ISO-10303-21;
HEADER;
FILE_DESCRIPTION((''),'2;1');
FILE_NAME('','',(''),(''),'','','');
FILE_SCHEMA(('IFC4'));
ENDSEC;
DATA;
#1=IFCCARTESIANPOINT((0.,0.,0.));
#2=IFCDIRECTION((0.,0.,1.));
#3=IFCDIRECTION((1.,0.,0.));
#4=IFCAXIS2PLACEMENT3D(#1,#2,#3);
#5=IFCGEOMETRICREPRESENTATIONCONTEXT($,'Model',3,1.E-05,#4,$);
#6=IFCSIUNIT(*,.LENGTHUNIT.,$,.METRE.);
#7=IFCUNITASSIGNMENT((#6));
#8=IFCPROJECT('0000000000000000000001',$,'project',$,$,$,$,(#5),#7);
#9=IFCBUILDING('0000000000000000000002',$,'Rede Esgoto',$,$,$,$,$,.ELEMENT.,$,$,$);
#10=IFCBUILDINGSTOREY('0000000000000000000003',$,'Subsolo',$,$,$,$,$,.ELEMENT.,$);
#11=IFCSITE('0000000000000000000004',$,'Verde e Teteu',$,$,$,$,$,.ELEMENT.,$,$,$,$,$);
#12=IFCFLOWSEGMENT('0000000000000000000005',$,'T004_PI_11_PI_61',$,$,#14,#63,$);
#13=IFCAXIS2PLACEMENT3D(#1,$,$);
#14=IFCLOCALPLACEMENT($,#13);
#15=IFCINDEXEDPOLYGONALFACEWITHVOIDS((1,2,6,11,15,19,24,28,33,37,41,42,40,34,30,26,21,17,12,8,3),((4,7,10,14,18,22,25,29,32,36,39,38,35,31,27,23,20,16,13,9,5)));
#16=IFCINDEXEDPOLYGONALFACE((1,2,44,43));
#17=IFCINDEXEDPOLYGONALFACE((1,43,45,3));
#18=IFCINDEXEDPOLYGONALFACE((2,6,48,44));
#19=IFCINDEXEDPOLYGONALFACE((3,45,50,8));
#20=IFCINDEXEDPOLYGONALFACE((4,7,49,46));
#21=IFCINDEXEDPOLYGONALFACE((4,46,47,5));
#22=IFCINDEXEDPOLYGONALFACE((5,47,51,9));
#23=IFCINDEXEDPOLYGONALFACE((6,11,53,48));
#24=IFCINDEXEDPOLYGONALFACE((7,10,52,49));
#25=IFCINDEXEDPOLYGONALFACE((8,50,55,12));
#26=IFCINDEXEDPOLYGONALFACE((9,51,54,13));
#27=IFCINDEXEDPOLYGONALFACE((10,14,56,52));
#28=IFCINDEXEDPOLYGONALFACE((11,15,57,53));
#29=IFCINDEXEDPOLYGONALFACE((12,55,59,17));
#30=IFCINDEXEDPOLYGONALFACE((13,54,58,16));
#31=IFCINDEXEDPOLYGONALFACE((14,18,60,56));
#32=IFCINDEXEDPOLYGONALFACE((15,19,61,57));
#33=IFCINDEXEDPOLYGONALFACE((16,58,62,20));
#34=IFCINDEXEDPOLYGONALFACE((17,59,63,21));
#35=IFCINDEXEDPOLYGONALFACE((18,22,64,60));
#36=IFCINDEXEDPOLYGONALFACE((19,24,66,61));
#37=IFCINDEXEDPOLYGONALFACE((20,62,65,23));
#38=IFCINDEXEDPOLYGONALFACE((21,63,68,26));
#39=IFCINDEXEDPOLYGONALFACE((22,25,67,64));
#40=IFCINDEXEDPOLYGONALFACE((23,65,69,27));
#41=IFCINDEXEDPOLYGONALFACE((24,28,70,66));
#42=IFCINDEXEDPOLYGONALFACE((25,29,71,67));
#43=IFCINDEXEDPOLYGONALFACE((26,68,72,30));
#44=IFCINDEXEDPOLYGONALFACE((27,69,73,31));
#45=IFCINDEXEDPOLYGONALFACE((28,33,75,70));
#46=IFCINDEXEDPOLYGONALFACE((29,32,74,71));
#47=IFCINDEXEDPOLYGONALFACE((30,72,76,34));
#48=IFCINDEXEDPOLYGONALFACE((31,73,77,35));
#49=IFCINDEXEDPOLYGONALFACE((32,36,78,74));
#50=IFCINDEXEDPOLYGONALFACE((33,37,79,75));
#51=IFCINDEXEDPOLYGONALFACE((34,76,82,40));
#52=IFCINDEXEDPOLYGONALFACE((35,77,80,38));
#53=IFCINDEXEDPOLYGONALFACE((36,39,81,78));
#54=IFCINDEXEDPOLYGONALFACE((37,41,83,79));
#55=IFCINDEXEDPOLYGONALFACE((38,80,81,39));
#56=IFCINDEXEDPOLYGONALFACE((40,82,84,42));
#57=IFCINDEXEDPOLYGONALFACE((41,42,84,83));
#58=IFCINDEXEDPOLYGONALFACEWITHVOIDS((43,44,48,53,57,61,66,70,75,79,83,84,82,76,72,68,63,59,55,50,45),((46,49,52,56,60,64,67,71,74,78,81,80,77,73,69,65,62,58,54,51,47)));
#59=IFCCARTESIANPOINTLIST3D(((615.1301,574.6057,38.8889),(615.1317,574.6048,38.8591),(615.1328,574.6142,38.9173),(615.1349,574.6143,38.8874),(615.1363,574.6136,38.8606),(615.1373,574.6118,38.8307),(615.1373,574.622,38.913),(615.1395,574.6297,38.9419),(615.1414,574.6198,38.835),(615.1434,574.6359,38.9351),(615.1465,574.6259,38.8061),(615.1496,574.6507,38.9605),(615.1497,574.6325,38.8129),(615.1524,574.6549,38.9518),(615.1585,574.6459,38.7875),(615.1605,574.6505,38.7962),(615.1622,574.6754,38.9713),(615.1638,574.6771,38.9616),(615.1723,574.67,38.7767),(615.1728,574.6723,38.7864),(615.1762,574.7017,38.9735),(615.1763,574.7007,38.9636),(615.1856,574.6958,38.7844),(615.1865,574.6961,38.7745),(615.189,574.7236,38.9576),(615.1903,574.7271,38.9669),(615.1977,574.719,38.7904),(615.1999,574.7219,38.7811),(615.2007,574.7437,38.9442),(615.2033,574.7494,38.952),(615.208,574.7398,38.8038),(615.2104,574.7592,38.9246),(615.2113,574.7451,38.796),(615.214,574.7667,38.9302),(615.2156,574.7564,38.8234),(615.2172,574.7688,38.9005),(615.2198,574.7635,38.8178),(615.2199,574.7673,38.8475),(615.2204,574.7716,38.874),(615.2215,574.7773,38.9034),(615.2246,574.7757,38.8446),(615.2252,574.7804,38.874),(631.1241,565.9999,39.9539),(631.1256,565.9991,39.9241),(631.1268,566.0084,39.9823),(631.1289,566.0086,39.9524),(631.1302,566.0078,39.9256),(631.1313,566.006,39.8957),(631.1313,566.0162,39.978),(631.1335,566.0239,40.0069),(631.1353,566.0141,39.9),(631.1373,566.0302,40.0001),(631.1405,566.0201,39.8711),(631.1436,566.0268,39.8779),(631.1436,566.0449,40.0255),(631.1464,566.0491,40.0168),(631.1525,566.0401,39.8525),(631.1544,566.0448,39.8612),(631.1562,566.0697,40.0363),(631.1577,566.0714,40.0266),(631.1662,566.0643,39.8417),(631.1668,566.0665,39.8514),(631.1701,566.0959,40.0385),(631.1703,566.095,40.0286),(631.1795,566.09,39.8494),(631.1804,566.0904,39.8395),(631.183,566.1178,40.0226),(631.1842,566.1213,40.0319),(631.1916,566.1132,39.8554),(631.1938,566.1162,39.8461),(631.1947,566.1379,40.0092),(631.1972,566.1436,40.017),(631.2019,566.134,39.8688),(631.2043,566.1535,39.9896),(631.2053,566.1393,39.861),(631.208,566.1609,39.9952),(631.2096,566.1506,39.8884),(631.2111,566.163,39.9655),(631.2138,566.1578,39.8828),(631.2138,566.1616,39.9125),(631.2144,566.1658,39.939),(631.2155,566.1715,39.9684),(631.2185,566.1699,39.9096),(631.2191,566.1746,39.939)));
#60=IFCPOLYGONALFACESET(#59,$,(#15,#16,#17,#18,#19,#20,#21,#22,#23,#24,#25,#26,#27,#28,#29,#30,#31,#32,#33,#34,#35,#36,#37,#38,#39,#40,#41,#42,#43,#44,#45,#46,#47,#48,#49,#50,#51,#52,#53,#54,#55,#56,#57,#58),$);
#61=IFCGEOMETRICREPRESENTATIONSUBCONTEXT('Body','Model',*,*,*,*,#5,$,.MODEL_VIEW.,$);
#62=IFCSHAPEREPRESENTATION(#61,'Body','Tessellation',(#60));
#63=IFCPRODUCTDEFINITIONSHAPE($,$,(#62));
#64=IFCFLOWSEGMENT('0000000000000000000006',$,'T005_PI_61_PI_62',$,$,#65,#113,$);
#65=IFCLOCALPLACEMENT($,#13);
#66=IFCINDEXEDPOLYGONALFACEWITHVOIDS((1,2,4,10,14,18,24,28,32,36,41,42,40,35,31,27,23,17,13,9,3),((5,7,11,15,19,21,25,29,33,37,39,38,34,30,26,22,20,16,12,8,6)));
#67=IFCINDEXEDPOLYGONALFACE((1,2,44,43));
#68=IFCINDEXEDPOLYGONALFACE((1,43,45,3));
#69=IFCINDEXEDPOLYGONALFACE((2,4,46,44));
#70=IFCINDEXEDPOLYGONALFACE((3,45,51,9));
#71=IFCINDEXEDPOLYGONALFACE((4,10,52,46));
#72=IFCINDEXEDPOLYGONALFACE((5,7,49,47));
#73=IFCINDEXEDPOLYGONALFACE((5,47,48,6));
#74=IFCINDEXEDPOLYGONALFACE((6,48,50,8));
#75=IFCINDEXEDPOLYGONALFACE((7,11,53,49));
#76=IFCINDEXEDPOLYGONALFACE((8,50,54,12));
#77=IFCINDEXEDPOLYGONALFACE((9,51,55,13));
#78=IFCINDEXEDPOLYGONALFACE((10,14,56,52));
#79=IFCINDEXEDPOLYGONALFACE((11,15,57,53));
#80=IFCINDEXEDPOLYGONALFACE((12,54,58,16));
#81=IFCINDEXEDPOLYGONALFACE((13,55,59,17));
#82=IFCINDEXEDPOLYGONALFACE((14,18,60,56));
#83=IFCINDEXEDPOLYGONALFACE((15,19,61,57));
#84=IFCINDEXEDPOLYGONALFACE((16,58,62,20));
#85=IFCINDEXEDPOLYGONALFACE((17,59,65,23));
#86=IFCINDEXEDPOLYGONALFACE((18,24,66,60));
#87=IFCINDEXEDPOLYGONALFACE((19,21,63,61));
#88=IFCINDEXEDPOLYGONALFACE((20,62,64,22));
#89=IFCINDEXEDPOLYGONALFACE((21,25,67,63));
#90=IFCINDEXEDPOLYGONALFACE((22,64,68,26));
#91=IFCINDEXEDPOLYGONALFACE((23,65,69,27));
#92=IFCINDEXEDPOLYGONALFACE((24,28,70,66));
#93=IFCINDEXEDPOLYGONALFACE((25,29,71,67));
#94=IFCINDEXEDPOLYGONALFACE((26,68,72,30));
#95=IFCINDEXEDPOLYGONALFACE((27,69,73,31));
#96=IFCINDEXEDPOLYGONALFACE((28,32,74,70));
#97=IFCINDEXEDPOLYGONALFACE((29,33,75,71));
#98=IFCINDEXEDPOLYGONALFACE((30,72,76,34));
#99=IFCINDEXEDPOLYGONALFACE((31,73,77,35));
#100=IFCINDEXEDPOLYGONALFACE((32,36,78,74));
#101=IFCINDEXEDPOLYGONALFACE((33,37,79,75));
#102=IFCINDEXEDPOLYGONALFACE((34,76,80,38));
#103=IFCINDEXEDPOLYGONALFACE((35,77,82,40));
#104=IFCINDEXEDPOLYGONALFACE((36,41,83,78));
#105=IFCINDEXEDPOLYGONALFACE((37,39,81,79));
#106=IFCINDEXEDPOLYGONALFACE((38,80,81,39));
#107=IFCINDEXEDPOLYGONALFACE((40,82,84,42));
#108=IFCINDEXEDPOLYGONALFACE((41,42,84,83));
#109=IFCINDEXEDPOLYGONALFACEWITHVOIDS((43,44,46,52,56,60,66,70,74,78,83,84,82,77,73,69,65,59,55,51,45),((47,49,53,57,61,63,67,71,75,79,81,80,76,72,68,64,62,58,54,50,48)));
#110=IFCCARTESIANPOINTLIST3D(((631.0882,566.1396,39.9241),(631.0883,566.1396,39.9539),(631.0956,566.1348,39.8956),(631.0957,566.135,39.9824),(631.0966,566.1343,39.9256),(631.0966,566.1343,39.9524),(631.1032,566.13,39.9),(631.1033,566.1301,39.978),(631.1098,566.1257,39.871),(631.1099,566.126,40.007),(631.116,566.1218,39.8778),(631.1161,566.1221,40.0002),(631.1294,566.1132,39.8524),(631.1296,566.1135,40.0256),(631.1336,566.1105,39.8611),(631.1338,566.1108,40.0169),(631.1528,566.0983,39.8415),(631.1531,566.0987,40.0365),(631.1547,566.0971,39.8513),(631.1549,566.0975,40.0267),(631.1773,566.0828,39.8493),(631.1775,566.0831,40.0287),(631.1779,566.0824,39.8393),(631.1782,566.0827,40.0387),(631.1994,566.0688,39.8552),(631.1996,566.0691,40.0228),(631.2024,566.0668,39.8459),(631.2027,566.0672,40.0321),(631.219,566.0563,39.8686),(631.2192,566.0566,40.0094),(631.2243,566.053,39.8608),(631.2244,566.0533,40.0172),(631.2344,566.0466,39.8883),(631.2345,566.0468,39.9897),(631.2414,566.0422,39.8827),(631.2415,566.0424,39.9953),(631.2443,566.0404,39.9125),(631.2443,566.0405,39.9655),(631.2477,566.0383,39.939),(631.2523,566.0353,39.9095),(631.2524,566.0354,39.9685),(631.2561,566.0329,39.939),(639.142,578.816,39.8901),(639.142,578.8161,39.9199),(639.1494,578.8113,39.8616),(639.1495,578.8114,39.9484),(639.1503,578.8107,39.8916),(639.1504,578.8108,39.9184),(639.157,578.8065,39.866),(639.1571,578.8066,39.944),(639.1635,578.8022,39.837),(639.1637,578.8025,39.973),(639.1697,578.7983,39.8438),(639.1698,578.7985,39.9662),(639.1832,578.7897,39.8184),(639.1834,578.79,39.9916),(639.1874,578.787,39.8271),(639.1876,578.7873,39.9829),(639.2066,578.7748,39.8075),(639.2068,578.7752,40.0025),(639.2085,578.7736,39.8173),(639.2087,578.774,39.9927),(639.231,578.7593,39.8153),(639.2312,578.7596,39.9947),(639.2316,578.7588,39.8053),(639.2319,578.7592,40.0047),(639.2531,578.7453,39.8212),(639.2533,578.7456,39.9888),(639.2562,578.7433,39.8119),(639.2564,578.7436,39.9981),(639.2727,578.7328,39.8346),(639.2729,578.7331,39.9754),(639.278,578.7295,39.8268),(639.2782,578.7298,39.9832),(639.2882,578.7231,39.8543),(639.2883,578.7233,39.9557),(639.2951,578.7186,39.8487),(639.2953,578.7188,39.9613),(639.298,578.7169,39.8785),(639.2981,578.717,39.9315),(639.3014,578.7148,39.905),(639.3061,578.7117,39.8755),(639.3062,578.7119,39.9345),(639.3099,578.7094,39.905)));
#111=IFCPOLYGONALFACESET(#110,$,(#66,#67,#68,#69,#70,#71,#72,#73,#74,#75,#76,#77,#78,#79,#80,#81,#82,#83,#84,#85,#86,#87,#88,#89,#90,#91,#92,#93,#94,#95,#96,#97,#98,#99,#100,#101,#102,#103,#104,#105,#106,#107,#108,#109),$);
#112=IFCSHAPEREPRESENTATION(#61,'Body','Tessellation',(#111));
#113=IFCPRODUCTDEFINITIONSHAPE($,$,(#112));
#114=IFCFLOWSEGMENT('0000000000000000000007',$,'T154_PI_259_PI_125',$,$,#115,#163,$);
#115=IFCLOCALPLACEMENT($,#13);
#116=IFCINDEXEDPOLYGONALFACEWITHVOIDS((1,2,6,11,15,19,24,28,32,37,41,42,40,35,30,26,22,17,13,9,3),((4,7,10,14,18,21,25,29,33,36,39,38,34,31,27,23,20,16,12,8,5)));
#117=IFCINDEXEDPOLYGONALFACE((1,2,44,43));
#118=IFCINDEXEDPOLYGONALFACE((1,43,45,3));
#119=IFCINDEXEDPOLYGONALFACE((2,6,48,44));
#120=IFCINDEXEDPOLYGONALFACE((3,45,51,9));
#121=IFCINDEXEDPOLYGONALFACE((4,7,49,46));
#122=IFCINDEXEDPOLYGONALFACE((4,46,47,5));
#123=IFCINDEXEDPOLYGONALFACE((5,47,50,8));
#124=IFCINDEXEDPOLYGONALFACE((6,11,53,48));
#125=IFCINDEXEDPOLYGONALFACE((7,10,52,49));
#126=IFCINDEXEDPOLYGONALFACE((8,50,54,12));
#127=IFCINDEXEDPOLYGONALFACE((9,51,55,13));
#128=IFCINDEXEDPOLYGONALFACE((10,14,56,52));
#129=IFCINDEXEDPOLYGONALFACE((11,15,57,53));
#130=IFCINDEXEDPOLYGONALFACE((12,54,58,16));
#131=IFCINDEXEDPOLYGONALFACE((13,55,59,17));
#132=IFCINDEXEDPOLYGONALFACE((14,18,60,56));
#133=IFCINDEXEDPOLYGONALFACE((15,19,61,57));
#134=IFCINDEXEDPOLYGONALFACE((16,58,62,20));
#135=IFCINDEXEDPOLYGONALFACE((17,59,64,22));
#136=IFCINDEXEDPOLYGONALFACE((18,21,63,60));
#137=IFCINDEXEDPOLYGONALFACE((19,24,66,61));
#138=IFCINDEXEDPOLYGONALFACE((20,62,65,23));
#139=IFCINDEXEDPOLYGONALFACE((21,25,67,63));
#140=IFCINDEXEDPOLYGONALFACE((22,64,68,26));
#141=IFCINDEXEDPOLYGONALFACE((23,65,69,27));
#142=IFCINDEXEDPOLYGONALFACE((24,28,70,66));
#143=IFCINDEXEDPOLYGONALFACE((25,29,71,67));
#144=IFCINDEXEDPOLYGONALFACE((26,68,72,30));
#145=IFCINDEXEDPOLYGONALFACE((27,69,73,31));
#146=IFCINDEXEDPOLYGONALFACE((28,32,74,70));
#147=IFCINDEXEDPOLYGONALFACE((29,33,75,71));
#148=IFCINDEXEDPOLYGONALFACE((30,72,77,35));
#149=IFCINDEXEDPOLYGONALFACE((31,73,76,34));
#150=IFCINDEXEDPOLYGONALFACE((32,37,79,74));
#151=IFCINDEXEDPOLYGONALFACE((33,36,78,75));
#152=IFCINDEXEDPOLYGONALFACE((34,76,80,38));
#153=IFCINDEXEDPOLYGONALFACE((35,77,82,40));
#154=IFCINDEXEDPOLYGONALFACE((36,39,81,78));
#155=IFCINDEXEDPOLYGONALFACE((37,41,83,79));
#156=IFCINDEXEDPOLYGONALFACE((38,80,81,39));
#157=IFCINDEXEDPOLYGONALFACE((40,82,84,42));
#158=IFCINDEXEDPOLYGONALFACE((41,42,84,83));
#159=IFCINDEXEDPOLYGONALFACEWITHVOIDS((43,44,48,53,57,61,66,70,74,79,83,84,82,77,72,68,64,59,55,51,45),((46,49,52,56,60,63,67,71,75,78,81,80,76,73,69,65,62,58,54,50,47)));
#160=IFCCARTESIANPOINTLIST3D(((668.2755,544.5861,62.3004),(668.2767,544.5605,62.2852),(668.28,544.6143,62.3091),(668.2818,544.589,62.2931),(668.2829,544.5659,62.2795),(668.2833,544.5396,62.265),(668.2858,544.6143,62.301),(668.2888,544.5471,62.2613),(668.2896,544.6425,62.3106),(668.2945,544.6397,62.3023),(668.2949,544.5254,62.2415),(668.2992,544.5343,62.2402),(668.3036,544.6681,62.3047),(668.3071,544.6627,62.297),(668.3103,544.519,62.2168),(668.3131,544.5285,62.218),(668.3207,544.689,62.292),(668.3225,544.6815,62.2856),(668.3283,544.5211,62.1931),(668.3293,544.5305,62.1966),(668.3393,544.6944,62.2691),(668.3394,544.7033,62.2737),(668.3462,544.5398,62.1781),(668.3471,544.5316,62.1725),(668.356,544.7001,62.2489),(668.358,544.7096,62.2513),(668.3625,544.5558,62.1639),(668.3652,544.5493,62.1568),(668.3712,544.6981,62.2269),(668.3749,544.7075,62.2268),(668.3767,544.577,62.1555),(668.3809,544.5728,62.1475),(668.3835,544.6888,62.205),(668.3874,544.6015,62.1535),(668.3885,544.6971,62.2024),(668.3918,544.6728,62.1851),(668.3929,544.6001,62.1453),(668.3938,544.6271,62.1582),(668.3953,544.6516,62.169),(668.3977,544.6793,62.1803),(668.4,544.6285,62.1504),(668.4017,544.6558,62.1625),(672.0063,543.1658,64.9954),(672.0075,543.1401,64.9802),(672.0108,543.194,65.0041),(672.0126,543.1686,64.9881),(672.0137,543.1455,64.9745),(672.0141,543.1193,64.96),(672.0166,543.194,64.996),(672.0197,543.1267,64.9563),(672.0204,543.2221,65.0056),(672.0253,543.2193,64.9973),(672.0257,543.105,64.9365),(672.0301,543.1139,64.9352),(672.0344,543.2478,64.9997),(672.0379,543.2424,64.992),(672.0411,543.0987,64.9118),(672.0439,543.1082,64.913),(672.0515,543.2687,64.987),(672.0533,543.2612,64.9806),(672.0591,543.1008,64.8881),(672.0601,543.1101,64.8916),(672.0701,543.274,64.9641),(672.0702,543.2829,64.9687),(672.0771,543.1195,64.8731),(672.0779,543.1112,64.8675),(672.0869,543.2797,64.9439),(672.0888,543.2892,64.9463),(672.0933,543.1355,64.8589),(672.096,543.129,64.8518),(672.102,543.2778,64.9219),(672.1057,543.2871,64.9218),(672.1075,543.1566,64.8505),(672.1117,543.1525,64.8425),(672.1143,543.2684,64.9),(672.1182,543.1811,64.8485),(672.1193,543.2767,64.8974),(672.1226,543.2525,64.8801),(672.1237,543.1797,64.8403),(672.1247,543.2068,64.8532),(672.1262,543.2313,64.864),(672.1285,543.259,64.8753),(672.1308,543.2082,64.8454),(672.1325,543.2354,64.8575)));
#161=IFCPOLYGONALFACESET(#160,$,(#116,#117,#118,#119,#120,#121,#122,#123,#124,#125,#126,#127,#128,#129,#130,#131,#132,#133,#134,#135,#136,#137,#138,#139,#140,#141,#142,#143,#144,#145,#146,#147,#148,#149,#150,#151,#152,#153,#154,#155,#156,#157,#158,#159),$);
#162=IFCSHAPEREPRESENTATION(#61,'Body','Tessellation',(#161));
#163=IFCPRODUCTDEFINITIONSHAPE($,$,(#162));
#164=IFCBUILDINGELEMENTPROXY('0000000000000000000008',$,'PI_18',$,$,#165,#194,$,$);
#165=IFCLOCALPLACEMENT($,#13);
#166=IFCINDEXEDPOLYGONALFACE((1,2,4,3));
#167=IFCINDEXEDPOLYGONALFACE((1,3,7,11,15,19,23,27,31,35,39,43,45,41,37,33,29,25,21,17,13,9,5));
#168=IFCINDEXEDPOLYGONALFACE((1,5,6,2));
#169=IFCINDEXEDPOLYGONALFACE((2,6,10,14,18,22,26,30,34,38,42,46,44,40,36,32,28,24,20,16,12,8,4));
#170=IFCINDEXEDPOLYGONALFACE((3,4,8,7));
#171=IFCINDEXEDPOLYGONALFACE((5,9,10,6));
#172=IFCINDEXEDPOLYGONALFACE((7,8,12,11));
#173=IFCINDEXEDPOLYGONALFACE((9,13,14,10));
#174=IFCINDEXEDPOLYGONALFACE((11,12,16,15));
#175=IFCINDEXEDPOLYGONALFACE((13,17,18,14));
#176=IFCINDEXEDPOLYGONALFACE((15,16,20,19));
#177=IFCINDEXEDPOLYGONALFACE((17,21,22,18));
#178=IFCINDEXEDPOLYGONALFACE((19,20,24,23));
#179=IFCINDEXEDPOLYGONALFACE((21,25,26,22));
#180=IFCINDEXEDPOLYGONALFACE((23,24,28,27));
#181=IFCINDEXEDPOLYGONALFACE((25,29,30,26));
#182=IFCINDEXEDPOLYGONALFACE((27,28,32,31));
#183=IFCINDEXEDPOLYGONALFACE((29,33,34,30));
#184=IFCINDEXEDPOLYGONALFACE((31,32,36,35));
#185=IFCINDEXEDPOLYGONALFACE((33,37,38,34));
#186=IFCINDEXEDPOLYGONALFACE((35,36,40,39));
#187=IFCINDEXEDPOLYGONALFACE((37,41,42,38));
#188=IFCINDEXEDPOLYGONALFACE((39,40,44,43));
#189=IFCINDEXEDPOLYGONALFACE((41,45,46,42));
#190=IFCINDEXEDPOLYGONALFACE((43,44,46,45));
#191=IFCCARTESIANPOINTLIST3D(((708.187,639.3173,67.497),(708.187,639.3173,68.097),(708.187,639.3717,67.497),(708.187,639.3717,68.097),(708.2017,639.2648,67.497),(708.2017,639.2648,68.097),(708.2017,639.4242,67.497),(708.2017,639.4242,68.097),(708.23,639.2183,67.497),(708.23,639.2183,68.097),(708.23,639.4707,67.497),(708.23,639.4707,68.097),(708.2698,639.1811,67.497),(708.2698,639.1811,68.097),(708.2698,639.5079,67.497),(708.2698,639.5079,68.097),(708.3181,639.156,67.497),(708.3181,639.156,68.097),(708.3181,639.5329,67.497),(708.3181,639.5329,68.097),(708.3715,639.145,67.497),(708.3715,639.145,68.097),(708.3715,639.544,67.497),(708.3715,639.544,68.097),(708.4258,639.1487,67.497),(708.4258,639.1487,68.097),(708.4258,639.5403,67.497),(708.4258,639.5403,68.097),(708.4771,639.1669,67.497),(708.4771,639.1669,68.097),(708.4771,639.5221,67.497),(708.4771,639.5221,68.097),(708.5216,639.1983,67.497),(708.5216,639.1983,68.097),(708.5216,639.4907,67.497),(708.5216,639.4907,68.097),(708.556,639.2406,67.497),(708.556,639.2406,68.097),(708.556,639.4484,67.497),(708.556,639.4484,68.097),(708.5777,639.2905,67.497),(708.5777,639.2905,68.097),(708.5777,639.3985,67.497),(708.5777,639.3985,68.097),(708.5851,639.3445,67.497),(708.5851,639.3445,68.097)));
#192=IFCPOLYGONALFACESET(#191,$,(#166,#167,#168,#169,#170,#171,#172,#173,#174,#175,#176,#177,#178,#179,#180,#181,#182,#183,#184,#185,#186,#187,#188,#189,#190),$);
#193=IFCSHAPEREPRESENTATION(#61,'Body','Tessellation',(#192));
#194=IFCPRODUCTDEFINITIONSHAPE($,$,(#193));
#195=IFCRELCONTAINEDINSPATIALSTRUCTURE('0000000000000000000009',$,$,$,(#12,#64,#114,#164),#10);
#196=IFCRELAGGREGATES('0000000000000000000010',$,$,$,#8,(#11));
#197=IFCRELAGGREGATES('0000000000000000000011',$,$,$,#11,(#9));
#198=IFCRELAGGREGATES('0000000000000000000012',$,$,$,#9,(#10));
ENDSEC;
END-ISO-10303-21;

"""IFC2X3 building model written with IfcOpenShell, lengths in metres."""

from ifc_helpers import new_model, entity, si_unit, frame, origin_with_axes, origin_2d, place, context, subcontext, project, spatial, circle, extrude, element, save


model = new_model("IFC2X3")

# Units and contexts
model_context = context("Model", 3, precision=1e-05, world=origin_with_axes())
body_context = subcontext(model_context, "Body", "Model", "MODEL_VIEW")
ifc_project = project(units=[si_unit("LENGTHUNIT", "METRE")], contexts=[model_context])

# Site, building, storey
site = spatial("IfcSite", under=ifc_project, Name="Verde e Teteu", CompositionType="ELEMENT")
building = spatial("IfcBuilding", under=site, Name="Rede Esgoto", CompositionType="ELEMENT")
storey = spatial("IfcBuildingStorey", under=building, Name="Subsolo", CompositionType="ELEMENT")

# Flow segments
flow_segment_1_placement = place(None, frame((615.1778, 574.6923, 38.874), z_axis=(0.0, 0.0, 1.0), x_axis=(1.0, 0.0, 0.0)))
element("IfcFlowSegment", 1, at=flow_segment_1_placement, inside=storey, Name="T004_PI_11_PI_61", context=body_context, shape_type="SweptSolid", body=[
    entity("IfcSweptDiskSolid", entity("IfcPolyline", [entity("IfcCartesianPoint", [0.0, 0.0, 0.0]), entity("IfcCartesianPoint", [15.994, -8.6058, 1.065])]), 0.1, 0.09),
])
flow_segment_2_placement = place(None, frame((631.1717, 566.0866, 39.939), z_axis=(0.0, 0.0, 1.0), x_axis=(1.0, 0.0, 0.0)))
element("IfcFlowSegment", 2, at=flow_segment_2_placement, inside=storey, Name="T005_PI_61_PI_62", context=body_context, shape_type="SweptSolid", body=[
    entity("IfcSweptDiskSolid", entity("IfcPolyline", [entity("IfcCartesianPoint", [0.0, 0.0, 0.0]), entity("IfcCartesianPoint", [8.0537, 12.6765, -0.034])]), 0.1, 0.09),
])
flow_segment_3_placement = place(None, frame((668.3385, 544.6143, 62.228), z_axis=(0.0, 0.0, 1.0), x_axis=(1.0, 0.0, 0.0)))
element("IfcFlowSegment", 3, at=flow_segment_3_placement, inside=storey, Name="T154_PI_259_PI_125", context=body_context, shape_type="SweptSolid", body=[
    entity("IfcSweptDiskSolid", entity("IfcPolyline", [entity("IfcCartesianPoint", [0.0, 0.0, 0.0]), entity("IfcCartesianPoint", [3.7308, -1.4203, 2.695])]), 0.1, 0.09),
])

# Building element proxy
proxy_1_placement = place(None, frame((708.3851, 639.3445, 67.497), z_axis=(0.0, 0.0, 1.0), x_axis=(1.0, 0.0, 0.0)))
element("IfcBuildingElementProxy", 4, at=proxy_1_placement, inside=storey, Name="PI_18", context=body_context, shape_type="SweptSolid", body=[
    extrude(circle(Radius=0.2, at=origin_2d()), origin_with_axes(), (0.0, 0.0, 1.0), 0.6),
])

save(model, "model.ifc")
